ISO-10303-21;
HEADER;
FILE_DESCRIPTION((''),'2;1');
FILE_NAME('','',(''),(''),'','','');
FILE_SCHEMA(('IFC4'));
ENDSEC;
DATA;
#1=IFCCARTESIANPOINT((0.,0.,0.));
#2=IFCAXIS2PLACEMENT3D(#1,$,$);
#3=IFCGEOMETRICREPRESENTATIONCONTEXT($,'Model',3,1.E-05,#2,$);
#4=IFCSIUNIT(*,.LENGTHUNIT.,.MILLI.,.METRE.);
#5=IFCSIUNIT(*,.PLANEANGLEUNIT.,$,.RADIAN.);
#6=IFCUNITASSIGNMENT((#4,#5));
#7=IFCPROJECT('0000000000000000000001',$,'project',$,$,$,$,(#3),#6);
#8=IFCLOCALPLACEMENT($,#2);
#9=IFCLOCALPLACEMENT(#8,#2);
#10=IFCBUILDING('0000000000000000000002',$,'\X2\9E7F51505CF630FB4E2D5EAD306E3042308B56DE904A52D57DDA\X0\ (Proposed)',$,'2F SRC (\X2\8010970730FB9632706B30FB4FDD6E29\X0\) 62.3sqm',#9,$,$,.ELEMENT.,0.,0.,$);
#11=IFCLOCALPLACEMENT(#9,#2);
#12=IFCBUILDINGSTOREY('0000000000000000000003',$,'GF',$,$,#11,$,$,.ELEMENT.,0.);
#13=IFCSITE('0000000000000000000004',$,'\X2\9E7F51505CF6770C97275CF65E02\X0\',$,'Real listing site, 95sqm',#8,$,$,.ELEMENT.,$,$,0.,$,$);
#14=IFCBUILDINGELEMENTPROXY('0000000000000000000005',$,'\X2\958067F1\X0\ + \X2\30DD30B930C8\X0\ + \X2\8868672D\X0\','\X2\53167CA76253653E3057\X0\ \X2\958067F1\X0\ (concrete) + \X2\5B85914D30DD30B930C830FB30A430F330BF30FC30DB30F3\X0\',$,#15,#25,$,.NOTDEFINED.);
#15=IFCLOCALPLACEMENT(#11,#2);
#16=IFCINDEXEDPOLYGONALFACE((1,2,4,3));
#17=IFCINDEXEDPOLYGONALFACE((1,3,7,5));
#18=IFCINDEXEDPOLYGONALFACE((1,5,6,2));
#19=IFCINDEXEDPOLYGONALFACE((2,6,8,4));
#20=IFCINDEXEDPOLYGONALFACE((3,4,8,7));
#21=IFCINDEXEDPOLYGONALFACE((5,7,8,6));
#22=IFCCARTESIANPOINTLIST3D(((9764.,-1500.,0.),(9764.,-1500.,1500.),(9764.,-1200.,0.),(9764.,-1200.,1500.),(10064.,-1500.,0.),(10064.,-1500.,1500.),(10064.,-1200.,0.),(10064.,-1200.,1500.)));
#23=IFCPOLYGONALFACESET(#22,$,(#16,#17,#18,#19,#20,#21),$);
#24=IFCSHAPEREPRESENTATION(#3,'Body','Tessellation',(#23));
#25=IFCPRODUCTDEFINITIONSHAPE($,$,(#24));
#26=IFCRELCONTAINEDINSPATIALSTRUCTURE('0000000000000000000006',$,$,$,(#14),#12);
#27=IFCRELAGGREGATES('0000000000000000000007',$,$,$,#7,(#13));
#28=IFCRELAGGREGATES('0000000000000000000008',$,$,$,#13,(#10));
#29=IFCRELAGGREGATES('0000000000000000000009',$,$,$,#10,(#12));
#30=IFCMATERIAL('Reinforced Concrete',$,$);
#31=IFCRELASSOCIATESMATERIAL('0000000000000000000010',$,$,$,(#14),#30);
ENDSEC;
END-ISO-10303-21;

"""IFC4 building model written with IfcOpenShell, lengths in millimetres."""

from ifc_helpers import new_model, si_unit, frame, frame_2d, origin, place, context, project, spatial, rectangle, extrude, material, element, save


model = new_model("IFC4")

# Units and contexts
model_context = context("Model", 3, precision=1e-05, world=origin())
ifc_project = project(units=[si_unit("LENGTHUNIT", "METRE", prefix="MILLI"), si_unit("PLANEANGLEUNIT", "RADIAN")], contexts=[model_context])

# Site, building, storey
site_placement = place(None, origin())
site = spatial("IfcSite", under=ifc_project, at=site_placement, Name="鹿児島県霧島市", ObjectType="Real listing site, 95sqm", CompositionType="ELEMENT", RefElevation=0.0)
building_placement = place(site_placement, origin())
building = spatial("IfcBuilding", under=site, at=building_placement, Name="鹿児島・中庭のある回遊動線 (Proposed)", ObjectType="2F SRC (耐震・防火・保温) 62.3sqm", CompositionType="ELEMENT", ElevationOfRefHeight=0.0, ElevationOfTerrain=0.0)
storey_placement = place(building_placement, origin())
storey = spatial("IfcBuildingStorey", under=building, at=storey_placement, Name="GF", CompositionType="ELEMENT", Elevation=0.0)

# Shared definitions
ifc_material_1 = material(Name="Reinforced Concrete")

# Building element proxy
proxy_placement = place(storey_placement, frame((4882.0, -750.0, 0.0)))
element("IfcBuildingElementProxy", 1, at=proxy_placement, inside=storey, material=ifc_material_1, Name="門柱 + ポスト + 表札", Description="化粧打放し 門柱 (concrete) + 宅配ポスト・インターホン", PredefinedType="NOTDEFINED", context=model_context, shape_type="SweptSolid", body=[
    extrude(rectangle(XDim=300.0, YDim=300.0, at=frame_2d((150.0, 150.0))), frame((4882.0, -750.0, 0.0)), (0.0, 0.0, 1.0), 1500.0),
])

save(model, "model.ifc")
